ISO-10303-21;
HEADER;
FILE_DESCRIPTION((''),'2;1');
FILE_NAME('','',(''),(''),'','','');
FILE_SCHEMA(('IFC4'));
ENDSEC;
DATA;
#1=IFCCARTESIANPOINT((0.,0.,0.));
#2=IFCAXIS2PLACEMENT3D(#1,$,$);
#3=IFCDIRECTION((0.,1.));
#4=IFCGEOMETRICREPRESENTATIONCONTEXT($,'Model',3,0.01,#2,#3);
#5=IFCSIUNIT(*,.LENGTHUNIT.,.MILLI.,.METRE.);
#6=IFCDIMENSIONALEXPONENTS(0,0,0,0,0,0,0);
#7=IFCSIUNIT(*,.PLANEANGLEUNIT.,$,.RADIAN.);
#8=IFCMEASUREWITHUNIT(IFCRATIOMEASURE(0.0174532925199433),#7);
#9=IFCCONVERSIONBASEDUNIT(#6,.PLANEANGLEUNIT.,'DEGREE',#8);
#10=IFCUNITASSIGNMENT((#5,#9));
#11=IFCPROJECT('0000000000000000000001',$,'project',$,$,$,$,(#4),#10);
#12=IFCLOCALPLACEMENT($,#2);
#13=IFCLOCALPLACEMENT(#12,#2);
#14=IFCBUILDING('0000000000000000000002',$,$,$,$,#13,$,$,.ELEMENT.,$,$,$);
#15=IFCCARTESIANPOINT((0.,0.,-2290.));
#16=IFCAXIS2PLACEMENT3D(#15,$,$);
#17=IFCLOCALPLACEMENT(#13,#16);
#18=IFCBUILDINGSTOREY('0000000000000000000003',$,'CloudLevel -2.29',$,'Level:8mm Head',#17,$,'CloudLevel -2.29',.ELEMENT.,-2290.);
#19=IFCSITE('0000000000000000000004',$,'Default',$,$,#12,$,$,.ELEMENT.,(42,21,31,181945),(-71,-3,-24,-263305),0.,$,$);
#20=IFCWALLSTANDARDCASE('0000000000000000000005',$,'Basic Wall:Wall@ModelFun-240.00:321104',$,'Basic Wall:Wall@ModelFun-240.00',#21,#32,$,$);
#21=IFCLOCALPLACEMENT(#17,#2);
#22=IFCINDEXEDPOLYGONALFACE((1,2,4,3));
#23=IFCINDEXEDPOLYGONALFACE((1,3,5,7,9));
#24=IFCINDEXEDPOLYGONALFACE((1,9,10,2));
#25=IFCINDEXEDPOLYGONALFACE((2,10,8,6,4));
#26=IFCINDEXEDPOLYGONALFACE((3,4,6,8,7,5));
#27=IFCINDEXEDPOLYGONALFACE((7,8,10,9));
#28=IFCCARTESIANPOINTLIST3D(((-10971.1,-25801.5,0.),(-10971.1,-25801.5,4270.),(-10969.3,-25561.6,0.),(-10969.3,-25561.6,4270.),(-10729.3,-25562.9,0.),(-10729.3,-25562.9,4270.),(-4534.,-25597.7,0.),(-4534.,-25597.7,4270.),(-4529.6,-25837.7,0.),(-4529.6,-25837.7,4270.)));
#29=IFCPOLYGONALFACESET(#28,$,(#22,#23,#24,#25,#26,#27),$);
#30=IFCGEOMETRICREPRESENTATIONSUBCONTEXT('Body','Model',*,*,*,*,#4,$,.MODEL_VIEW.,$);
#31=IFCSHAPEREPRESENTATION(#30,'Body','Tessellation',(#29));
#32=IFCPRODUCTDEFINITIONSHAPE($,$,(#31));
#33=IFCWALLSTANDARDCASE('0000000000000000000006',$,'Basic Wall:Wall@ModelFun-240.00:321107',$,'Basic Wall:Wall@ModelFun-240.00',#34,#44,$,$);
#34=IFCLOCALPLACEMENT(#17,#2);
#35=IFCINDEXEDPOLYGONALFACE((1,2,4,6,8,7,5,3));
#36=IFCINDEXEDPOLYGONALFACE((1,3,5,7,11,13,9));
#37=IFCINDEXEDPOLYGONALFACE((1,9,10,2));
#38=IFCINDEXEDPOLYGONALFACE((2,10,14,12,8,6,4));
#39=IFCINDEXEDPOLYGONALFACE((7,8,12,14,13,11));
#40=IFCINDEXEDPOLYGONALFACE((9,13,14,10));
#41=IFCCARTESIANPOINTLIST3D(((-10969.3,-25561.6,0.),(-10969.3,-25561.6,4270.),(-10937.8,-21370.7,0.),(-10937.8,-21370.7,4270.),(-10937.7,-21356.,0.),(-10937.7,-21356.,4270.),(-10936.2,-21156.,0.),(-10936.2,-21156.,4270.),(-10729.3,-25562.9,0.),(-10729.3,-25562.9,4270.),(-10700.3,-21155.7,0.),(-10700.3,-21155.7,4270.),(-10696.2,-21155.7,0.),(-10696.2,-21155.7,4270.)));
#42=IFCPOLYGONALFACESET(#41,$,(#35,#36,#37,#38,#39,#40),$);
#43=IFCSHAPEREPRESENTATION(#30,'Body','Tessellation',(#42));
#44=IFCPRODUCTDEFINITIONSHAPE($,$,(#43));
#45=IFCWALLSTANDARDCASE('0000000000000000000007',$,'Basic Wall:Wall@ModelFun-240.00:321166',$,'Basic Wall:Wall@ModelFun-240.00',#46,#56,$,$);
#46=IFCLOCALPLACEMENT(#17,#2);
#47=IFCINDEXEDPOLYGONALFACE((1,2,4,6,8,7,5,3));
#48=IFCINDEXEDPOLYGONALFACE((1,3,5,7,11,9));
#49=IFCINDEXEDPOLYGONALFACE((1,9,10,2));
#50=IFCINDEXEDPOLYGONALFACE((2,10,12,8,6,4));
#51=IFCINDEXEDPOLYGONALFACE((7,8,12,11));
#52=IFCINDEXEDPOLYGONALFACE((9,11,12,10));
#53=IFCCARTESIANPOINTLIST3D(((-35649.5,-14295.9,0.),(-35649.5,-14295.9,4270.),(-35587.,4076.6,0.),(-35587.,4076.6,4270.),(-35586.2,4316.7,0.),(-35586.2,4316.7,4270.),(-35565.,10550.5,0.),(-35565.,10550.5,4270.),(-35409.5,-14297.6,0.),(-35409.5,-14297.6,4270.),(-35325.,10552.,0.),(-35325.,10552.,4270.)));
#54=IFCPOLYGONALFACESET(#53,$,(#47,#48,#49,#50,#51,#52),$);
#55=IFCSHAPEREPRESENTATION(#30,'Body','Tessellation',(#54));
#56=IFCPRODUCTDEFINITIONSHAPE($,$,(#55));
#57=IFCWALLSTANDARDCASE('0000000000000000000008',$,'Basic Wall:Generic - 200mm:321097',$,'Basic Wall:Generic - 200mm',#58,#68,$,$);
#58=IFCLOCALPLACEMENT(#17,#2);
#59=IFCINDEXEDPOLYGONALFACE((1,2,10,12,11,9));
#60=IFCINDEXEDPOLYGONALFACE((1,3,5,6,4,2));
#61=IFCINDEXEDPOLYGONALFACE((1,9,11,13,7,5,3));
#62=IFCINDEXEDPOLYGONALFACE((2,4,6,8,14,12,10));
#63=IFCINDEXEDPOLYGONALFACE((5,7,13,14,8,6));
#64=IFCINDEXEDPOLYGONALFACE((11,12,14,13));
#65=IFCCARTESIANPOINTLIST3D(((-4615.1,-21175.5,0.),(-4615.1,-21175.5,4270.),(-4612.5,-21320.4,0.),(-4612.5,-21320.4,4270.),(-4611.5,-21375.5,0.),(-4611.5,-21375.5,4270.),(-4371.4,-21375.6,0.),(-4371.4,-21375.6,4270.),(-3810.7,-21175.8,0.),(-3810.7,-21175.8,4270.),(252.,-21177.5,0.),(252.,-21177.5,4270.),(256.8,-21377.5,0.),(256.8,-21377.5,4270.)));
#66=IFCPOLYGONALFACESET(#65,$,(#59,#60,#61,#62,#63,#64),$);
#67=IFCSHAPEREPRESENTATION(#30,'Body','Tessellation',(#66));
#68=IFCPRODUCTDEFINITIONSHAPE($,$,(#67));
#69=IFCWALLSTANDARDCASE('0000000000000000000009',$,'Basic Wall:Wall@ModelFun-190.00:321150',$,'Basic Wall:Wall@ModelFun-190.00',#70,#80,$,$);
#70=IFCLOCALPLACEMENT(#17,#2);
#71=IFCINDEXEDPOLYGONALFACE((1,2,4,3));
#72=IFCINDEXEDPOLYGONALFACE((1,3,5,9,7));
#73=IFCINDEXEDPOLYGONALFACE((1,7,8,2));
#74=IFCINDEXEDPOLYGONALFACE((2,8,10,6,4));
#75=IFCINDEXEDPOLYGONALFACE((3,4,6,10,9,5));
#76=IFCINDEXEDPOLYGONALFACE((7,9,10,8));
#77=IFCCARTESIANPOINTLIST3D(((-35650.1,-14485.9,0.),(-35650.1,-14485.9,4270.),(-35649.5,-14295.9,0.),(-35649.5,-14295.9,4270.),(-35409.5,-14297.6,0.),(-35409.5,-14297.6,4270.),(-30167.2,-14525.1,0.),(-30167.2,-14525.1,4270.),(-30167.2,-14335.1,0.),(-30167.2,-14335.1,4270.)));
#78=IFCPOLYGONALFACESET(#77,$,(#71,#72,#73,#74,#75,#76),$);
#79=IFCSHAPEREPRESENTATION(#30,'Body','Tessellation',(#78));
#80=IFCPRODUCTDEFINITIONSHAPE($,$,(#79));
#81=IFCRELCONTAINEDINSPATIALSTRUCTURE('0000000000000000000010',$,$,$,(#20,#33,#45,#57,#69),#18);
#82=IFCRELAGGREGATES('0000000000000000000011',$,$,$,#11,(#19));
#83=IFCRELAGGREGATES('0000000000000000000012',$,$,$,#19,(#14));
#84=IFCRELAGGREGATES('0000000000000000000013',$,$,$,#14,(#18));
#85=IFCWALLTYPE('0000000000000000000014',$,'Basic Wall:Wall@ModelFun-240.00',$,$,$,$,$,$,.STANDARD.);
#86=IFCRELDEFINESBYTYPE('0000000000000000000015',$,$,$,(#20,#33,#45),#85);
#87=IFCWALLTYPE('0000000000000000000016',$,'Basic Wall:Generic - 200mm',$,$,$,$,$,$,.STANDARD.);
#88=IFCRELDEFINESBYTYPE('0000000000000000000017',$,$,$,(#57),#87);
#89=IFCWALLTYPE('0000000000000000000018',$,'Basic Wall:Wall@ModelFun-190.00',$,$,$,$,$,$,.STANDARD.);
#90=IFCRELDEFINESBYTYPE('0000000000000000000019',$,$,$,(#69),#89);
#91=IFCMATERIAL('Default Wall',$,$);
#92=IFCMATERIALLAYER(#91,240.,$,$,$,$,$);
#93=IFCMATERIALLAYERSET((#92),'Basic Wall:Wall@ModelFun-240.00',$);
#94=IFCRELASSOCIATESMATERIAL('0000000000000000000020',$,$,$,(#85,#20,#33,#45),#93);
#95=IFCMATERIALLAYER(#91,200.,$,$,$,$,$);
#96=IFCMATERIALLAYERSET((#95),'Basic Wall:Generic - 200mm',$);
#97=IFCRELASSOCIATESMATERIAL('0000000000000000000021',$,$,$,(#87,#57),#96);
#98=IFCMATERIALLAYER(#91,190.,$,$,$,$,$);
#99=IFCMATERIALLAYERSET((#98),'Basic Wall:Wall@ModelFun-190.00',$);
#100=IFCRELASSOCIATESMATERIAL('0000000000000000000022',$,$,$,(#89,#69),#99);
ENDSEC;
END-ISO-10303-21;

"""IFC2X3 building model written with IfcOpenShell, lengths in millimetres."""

from ifc_helpers import new_model, entity, si_unit, converted_unit, direction, frame, origin, place, context, subcontext, project, spatial, polyline, outline, extrude, material, layer, layer_set, layer_usage, type_object, element, save


model = new_model("IFC2X3")

# Units and contexts
model_context = context("Model", 3, precision=0.01, world=origin(), true_north=direction((0.0, 1.0)))
body_context = subcontext(model_context, "Body", "Model", "MODEL_VIEW")
ifc_project = project(units=[si_unit("LENGTHUNIT", "METRE", prefix="MILLI"), converted_unit("PLANEANGLEUNIT", "DEGREE", entity("IfcRatioMeasure", 0.0174532925199433), si_unit("PLANEANGLEUNIT", "RADIAN"), dimensions=[0, 0, 0, 0, 0, 0, 0])], contexts=[model_context])

# Site, building, storey
site_placement = place(None, origin())
site = spatial("IfcSite", under=ifc_project, at=site_placement, Name="Default", CompositionType="ELEMENT", RefLatitude=(42, 21, 31, 181945), RefLongitude=(-71, -3, -24, -263305), RefElevation=0.0)
building_placement = place(site_placement, origin())
building = spatial("IfcBuilding", under=site, at=building_placement, CompositionType="ELEMENT")
storey_placement = place(building_placement, frame((0.0, 0.0, -2290.0)))
storey = spatial("IfcBuildingStorey", under=building, at=storey_placement, Name="CloudLevel -2.29", ObjectType="Level:8mm Head", LongName="CloudLevel -2.29", CompositionType="ELEMENT", Elevation=-2290.0)

# Shared definitions
ifc_material_1 = material(Name="Default Wall")

# Walls
ifc_layer_1 = layer(ifc_material_1, 240.0)
ifc_layer_set_1 = layer_set([ifc_layer_1], Name="Basic Wall:Wall@ModelFun-240.00")
wall_type_1 = type_object("IfcWallType", Name="Basic Wall:Wall@ModelFun-240.00", PredefinedType="STANDARD", material=ifc_layer_set_1)
ifc_layer_usage_1 = layer_usage(ifc_layer_set_1, "AXIS2", "NEGATIVE", 120.0)
wall_1_placement = place(storey_placement, frame((-4528.9, -25717.7, 0.0), z_axis=(0.0, 0.0, 1.0), x_axis=(-0.999984, 0.00561, 0.0)))
element("IfcWallStandardCase", 1, at=wall_1_placement, inside=storey, type_object=wall_type_1, material=ifc_layer_usage_1, Name="Basic Wall:Wall@ModelFun-240.00:321104", ObjectType="Basic Wall:Wall@ModelFun-240.00", context=body_context, shape_type="SweptSolid", body=[
    extrude(outline(polyline([(6441.2, -120.0), (6441.7, 120.0), (0.0, 120.0), (5.8, -120.0), (6201.2, -120.0), (6441.2, -120.0)])), origin(), (0.0, 0.0, 1.0), 4270.0),
])
ifc_layer_usage_2 = layer_usage(ifc_layer_set_1, "AXIS2", "NEGATIVE", 120.0)
wall_2_placement = place(storey_placement, frame((-10849.3, -25562.5, 0.0), z_axis=(0.0, 0.0, 1.0), x_axis=(0.007528, 0.999972, 0.0)))
element("IfcWallStandardCase", 2, at=wall_2_placement, inside=storey, type_object=wall_type_1, material=ifc_layer_usage_2, Name="Basic Wall:Wall@ModelFun-240.00:321107", ObjectType="Basic Wall:Wall@ModelFun-240.00", context=body_context, shape_type="SweptSolid", body=[
    extrude(outline(polyline([(4407.8, -120.0), (4407.8, -115.8), (4405.6, 120.0), (4205.6, 120.0), (4190.9, 120.0), (0.0, 120.0), (0.5, -120.0), (4407.8, -120.0)])), origin(), (0.0, 0.0, 1.0), 4270.0),
])
ifc_layer_usage_3 = layer_usage(ifc_layer_set_1, "AXIS2", "NEGATIVE", 120.0)
wall_3_placement = place(storey_placement, frame((-35529.5, -14297.2, 0.0), z_axis=(0.0, 0.0, 1.0), x_axis=(0.003401, 0.999994, 0.0)))
element("IfcWallStandardCase", 3, at=wall_3_placement, inside=storey, type_object=wall_type_1, material=ifc_layer_usage_3, Name="Basic Wall:Wall@ModelFun-240.00:321166", ObjectType="Basic Wall:Wall@ModelFun-240.00", context=body_context, shape_type="SweptSolid", body=[
    extrude(outline(polyline([(24849.7, -120.0), (24847.4, 120.0), (18613.6, 120.0), (18373.5, 120.0), (0.9, 120.0), (0.0, -120.0), (24849.7, -120.0)])), origin(), (0.0, 0.0, 1.0), 4270.0),
])
ifc_layer_2 = layer(ifc_material_1, 200.0)
ifc_layer_set_2 = layer_set([ifc_layer_2], Name="Basic Wall:Generic - 200mm")
ifc_layer_usage_4 = layer_usage(ifc_layer_set_2, "AXIS2", "NEGATIVE", 100.0)
wall_type_2 = type_object("IfcWallType", Name="Basic Wall:Generic - 200mm", PredefinedType="STANDARD", material=ifc_layer_set_2)
wall_4_placement = place(storey_placement, frame((-4615.2, -21275.5, 0.0), z_axis=(0.0, 0.0, 1.0), x_axis=(1.0, -0.000399, 0.0)))
element("IfcWallStandardCase", 4, at=wall_4_placement, inside=storey, type_object=wall_type_2, material=ifc_layer_usage_4, Name="Basic Wall:Generic - 200mm:321097", ObjectType="Basic Wall:Generic - 200mm", context=body_context, shape_type="SweptSolid", body=[
    extrude(outline(polyline([(4872.0, -100.0), (4867.2, 100.0), (804.5, 100.0), (0.0, 100.0), (2.7, -44.9), (3.8, -100.0), (243.8, -100.0), (4872.0, -100.0)])), origin(), (0.0, 0.0, 1.0), 4270.0),
])
ifc_layer_3 = layer(ifc_material_1, 190.0)
ifc_layer_set_3 = layer_set([ifc_layer_3], Name="Basic Wall:Wall@ModelFun-190.00")
ifc_layer_usage_5 = layer_usage(ifc_layer_set_3, "AXIS2", "NEGATIVE", 95.0)
wall_type_3 = type_object("IfcWallType", Name="Basic Wall:Wall@ModelFun-190.00", PredefinedType="STANDARD", material=ifc_layer_set_3)
wall_5_placement = place(storey_placement, frame((-30166.5, -14430.1, 0.0), z_axis=(0.0, 0.0, 1.0), x_axis=(-0.999974, 0.007152, 0.0)))
element("IfcWallStandardCase", 5, at=wall_5_placement, inside=storey, type_object=wall_type_3, material=ifc_layer_usage_5, Name="Basic Wall:Wall@ModelFun-190.00:321150", ObjectType="Basic Wall:Wall@ModelFun-190.00", context=body_context, shape_type="SweptSolid", body=[
    extrude(outline(polyline([(5483.8, -95.0), (5483.1, 95.0), (0.0, 95.0), (1.4, -95.0), (5243.8, -95.0), (5483.8, -95.0)])), origin(), (0.0, 0.0, 1.0), 4270.0),
])

save(model, "model.ifc")
